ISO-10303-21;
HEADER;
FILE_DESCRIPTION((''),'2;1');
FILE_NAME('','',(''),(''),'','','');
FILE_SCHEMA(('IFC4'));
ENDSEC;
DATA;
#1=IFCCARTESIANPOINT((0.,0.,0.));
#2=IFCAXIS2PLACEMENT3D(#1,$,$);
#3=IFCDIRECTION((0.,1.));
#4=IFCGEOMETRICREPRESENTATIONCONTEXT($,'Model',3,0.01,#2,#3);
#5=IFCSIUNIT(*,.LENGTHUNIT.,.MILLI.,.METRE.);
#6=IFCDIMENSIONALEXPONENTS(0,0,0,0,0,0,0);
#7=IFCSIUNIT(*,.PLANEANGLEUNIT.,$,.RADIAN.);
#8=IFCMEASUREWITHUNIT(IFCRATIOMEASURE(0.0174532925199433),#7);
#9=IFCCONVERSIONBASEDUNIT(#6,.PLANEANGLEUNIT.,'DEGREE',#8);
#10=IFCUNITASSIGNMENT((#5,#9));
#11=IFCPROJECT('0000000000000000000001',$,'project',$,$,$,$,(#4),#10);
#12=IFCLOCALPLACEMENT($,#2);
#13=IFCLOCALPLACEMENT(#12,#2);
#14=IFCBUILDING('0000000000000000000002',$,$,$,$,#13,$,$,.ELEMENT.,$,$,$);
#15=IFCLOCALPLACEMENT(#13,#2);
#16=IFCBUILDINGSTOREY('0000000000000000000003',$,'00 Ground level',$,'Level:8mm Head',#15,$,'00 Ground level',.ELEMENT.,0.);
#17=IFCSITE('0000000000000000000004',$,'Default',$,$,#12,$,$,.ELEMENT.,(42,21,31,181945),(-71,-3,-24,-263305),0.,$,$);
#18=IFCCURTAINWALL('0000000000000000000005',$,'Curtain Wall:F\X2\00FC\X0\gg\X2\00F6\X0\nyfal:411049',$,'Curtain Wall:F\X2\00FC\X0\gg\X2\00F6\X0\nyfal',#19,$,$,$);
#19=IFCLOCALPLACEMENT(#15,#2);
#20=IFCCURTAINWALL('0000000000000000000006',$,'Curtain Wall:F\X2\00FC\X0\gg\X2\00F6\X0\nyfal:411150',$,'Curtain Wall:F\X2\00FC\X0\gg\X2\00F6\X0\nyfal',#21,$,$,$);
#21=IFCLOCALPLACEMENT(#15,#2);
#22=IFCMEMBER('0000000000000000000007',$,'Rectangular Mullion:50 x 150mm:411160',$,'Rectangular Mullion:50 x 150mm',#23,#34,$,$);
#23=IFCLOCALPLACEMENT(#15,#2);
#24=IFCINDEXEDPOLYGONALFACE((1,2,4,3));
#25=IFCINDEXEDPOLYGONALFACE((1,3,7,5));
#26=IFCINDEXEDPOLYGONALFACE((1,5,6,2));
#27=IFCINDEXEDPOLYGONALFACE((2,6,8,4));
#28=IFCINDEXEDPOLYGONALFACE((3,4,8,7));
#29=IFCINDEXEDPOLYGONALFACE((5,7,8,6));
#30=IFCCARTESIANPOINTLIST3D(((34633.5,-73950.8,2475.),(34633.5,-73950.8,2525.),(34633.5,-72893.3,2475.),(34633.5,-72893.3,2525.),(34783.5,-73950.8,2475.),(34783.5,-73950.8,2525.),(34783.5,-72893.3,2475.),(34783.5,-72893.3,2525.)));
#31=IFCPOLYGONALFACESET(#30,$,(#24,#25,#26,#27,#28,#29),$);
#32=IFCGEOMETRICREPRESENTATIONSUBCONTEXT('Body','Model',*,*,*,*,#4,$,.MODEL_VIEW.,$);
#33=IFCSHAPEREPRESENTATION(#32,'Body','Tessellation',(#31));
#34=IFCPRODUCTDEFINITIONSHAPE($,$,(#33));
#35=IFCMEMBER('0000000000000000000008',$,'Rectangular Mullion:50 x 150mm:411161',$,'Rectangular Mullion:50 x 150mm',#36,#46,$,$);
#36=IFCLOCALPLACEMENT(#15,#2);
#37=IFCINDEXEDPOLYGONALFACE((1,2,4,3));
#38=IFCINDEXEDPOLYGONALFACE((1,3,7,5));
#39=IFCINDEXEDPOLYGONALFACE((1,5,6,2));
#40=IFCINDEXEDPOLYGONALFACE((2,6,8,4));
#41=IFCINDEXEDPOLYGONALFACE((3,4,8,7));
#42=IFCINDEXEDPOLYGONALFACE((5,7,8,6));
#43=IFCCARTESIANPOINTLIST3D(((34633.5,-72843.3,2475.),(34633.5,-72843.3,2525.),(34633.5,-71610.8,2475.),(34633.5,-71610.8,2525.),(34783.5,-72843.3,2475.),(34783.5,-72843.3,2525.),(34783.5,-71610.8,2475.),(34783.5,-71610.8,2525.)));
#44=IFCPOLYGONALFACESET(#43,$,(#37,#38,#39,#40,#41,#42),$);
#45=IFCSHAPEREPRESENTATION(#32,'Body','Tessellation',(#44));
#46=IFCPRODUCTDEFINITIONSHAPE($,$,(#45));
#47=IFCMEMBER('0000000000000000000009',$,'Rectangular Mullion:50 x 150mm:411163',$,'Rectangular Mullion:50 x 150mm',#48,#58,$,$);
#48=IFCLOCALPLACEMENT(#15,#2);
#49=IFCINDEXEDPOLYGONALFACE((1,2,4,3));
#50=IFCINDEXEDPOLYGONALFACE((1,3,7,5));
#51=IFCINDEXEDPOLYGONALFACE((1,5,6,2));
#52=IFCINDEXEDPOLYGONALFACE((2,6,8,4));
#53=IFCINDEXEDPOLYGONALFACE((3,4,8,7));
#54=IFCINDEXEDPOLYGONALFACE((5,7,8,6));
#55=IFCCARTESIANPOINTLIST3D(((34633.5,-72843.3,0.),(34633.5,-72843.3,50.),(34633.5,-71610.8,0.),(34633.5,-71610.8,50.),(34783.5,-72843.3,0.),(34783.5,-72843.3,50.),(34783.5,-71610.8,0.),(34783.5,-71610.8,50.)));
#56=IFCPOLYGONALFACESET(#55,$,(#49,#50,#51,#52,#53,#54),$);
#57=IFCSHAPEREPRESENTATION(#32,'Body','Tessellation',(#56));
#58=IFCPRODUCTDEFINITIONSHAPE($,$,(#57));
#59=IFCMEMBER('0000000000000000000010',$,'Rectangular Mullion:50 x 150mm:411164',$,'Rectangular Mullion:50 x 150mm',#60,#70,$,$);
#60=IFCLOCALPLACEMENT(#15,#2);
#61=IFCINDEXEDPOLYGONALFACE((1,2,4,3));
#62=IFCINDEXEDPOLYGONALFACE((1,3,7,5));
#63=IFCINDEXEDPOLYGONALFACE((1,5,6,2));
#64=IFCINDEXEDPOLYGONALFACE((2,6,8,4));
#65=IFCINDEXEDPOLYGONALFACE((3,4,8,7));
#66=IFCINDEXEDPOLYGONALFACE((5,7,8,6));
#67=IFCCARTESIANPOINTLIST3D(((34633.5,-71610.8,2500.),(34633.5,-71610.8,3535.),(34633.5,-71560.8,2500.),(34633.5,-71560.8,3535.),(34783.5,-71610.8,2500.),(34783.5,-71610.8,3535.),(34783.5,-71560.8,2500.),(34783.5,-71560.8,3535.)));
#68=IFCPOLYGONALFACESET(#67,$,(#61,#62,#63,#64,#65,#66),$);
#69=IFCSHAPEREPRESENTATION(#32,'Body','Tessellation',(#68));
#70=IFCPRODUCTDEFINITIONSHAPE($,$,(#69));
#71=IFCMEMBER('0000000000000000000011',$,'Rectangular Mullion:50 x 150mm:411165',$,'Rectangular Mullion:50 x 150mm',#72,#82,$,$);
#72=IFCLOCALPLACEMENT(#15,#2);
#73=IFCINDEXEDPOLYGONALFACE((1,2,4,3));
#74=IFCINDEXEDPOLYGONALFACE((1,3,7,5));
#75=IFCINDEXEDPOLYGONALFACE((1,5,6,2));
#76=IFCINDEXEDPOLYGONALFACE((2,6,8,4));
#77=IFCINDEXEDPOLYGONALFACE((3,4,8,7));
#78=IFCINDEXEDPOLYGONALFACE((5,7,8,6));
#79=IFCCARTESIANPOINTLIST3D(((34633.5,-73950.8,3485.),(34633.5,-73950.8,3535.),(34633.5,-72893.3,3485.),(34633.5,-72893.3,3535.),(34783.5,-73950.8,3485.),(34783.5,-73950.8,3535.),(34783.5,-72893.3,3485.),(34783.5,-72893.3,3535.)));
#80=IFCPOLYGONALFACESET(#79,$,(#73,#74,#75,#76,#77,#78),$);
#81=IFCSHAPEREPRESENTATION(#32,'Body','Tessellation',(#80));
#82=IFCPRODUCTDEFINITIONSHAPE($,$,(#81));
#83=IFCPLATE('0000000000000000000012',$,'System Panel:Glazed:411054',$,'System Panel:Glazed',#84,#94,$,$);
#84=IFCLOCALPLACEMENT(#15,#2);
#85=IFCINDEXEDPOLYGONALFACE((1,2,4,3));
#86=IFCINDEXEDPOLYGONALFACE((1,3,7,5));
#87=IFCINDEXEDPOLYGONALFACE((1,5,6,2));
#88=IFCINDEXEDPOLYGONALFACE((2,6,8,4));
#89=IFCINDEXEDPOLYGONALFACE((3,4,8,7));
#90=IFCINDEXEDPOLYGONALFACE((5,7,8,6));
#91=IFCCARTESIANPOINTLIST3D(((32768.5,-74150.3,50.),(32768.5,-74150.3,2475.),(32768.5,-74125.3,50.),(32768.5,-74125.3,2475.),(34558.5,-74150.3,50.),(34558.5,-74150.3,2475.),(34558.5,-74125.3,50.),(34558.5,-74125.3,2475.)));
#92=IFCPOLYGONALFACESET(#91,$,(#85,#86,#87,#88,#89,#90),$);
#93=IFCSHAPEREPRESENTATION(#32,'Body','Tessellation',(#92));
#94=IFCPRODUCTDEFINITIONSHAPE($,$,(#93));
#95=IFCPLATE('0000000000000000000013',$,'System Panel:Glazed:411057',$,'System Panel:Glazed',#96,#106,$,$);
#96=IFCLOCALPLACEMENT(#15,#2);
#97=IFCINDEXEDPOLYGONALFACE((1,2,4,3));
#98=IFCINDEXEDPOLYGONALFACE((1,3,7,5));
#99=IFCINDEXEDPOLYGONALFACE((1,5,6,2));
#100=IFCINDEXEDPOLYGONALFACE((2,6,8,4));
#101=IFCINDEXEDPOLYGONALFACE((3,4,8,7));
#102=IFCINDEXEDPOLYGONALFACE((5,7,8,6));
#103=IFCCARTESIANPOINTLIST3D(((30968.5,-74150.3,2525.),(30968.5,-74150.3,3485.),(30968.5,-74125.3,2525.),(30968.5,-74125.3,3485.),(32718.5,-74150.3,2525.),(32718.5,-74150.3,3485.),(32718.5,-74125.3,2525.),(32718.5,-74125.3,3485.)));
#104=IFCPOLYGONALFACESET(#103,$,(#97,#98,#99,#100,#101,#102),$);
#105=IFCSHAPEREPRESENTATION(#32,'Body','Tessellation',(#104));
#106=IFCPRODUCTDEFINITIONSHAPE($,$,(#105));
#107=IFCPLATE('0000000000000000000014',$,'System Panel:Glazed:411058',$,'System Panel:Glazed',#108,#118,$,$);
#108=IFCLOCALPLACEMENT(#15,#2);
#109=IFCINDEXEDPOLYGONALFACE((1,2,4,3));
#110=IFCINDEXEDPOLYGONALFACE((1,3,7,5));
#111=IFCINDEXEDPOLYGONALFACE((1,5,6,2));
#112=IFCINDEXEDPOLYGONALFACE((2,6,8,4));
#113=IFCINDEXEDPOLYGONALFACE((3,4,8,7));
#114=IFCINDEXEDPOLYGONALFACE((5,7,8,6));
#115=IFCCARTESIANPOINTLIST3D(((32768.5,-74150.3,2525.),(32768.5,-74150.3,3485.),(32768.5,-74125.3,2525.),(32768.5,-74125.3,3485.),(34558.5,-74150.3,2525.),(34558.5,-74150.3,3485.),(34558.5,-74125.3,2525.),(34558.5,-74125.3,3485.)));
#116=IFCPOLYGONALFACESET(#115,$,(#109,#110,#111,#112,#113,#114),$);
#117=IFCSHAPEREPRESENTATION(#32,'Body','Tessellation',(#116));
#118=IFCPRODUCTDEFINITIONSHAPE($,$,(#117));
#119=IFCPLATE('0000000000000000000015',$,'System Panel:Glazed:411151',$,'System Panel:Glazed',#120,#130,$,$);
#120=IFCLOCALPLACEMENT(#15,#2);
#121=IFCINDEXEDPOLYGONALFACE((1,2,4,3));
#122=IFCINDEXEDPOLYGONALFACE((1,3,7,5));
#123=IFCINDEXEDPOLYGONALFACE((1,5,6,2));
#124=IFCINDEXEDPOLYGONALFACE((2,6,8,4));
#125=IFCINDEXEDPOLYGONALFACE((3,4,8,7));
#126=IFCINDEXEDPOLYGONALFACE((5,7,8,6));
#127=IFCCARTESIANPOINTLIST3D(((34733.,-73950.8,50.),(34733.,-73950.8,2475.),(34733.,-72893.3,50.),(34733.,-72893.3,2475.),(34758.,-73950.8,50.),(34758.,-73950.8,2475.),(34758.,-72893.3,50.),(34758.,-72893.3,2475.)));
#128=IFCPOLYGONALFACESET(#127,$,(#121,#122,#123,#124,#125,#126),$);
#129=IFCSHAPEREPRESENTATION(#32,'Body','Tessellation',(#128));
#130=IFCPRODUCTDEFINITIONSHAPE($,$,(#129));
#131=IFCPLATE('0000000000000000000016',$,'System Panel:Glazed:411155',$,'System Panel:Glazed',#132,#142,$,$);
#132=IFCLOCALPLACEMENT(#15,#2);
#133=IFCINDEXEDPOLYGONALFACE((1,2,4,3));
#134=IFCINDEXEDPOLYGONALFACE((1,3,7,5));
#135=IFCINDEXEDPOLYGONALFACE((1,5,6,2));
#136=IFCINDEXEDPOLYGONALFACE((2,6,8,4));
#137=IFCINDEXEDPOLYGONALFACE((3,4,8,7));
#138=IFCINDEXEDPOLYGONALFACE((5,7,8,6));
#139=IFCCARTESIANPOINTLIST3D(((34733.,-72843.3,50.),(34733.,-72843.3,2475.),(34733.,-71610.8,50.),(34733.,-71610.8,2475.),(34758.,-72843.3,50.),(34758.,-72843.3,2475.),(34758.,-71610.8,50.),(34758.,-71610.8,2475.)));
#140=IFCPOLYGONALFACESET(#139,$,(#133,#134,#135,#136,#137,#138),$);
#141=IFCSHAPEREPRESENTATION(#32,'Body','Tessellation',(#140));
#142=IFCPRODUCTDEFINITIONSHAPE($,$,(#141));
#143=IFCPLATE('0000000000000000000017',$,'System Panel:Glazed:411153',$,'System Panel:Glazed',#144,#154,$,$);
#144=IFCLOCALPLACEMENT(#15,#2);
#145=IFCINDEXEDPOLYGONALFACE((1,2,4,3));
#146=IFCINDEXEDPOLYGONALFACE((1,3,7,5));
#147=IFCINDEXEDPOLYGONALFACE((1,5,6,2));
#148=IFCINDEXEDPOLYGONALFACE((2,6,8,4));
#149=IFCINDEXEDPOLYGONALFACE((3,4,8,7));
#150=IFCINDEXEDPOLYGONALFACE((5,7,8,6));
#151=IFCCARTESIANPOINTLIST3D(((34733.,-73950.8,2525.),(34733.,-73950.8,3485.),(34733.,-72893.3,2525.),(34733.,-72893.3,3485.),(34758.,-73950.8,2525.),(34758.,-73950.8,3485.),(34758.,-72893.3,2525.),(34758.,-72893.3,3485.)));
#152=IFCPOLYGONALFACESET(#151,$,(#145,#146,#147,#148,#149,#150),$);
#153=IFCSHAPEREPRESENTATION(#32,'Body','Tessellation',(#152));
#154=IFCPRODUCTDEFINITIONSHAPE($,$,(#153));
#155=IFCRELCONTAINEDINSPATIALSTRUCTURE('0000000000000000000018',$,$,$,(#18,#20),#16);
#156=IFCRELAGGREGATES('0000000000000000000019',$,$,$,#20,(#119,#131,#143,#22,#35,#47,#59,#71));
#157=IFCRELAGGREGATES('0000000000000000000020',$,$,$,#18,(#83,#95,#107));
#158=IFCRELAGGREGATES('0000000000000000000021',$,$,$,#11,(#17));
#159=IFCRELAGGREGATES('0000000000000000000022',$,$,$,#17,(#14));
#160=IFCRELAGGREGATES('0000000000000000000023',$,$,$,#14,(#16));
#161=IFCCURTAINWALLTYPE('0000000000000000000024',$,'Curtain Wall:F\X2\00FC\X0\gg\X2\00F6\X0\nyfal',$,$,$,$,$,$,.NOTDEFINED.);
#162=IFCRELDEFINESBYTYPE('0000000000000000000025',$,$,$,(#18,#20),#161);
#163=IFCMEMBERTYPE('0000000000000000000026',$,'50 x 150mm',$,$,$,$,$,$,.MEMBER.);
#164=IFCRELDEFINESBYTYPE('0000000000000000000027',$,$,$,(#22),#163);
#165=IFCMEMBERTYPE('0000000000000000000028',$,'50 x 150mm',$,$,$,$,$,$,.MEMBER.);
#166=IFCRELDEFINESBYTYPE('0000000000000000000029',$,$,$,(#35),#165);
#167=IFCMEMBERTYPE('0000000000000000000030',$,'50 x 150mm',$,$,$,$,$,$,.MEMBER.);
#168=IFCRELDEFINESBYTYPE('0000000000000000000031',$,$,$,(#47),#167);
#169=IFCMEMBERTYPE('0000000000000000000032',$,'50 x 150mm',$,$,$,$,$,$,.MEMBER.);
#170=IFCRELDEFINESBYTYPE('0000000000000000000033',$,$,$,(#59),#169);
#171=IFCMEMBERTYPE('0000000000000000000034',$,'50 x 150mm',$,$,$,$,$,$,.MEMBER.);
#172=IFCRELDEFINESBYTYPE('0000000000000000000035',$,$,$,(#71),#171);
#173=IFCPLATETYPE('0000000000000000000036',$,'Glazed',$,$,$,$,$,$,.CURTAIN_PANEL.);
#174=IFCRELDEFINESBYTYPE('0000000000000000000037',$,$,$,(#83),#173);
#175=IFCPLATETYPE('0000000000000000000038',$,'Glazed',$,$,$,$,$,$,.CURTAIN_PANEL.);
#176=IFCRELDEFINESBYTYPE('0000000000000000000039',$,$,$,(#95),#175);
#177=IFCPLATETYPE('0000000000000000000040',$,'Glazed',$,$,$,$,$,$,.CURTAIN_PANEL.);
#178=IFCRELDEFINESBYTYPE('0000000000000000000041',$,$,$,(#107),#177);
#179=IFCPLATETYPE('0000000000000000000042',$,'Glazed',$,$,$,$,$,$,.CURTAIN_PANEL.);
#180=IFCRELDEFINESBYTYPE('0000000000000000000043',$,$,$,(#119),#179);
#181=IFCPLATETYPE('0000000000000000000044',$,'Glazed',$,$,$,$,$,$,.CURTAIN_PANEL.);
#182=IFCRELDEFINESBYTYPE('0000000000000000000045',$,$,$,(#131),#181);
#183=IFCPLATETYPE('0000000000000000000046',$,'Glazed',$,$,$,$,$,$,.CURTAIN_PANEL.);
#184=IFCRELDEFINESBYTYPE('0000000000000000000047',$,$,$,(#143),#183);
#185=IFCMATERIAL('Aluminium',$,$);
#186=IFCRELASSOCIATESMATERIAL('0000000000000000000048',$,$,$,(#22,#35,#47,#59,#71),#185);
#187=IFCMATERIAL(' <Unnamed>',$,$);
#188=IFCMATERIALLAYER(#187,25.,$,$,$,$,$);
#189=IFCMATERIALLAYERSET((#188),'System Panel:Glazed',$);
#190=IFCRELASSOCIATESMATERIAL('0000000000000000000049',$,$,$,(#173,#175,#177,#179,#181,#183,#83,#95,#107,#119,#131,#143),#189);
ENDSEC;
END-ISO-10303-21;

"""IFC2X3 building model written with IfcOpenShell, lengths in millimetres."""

from ifc_helpers import new_model, entity, si_unit, converted_unit, direction, frame, frame_2d, origin, origin_2d_with_axis, place, context, subcontext, project, spatial, rectangle, extrude, source, transform, mapped, material, layer, layer_set, layer_usage, type_object, type_shapes, element, aggregate, save


model = new_model("IFC2X3")

# Units and contexts
model_context = context("Model", 3, precision=0.01, world=origin(), true_north=direction((0.0, 1.0)))
body_context = subcontext(model_context, "Body", "Model", "MODEL_VIEW")
ifc_project = project(units=[si_unit("LENGTHUNIT", "METRE", prefix="MILLI"), converted_unit("PLANEANGLEUNIT", "DEGREE", entity("IfcRatioMeasure", 0.0174532925199433), si_unit("PLANEANGLEUNIT", "RADIAN"), dimensions=[0, 0, 0, 0, 0, 0, 0])], contexts=[model_context])

# Site, building, storey
site_placement = place(None, origin())
site = spatial("IfcSite", under=ifc_project, at=site_placement, Name="Default", CompositionType="ELEMENT", RefLatitude=(42, 21, 31, 181945), RefLongitude=(-71, -3, -24, -263305), RefElevation=0.0)
building_placement = place(site_placement, origin())
building = spatial("IfcBuilding", under=site, at=building_placement, CompositionType="ELEMENT")
storey_placement = place(building_placement, origin())
storey = spatial("IfcBuildingStorey", under=building, at=storey_placement, Name="00 Ground level", ObjectType="Level:8mm Head", LongName="00 Ground level", CompositionType="ELEMENT", Elevation=0.0)

# Curtain wall
curtain_wall_type = type_object("IfcCurtainWallType", Name="Curtain Wall:Függönyfal", PredefinedType="NOTDEFINED")
curtain_wall_1_placement = place(storey_placement, origin())
curtain_wall_1 = element("IfcCurtainWall", 1, at=curtain_wall_1_placement, inside=storey, type_object=curtain_wall_type, Name="Curtain Wall:Függönyfal:411049", ObjectType="Curtain Wall:Függönyfal")
ifc_material_1 = material(Name="Aluminium")

# Curtain wall
curtain_wall_2_placement = place(storey_placement, origin())
curtain_wall_2 = element("IfcCurtainWall", 2, at=curtain_wall_2_placement, inside=storey, type_object=curtain_wall_type, Name="Curtain Wall:Függönyfal:411150", ObjectType="Curtain Wall:Függönyfal")

# Members
member_type_1 = type_object("IfcMemberType", Name="50 x 150mm", PredefinedType="MEMBER")
shared_shape_1 = source(origin(), body_context, "Body", "SweptSolid", [
    extrude(rectangle(XDim=150.0, YDim=50.0, at=origin_2d_with_axis()), frame((0.0, 0.0, -1057.5), z_axis=(0.0, 0.0, 1.0), x_axis=(0.0, -1.0, 0.0)), (0.0, 0.0, 1.0), 1057.5),
])
type_shapes(member_type_1, [shared_shape_1])
member_1_placement = place(storey_placement, frame((34708.5, -72893.3, 2500.0), z_axis=(0.0, 1.0, 0.0), x_axis=(0.0, 0.0, 1.0)))
member_1 = element("IfcMember", 3, at=member_1_placement, type_object=member_type_1, material=ifc_material_1, Name="Rectangular Mullion:50 x 150mm:411160", ObjectType="Rectangular Mullion:50 x 150mm", context=body_context, shape_type="MappedRepresentation", body=[
    mapped(shared_shape_1, transform((0.0, 0.0, 0.0), scale=1.0)),
])
member_type_2 = type_object("IfcMemberType", Name="50 x 150mm", PredefinedType="MEMBER")
shared_shape_2 = source(origin(), body_context, "Body", "SweptSolid", [
    extrude(rectangle(XDim=150.0, YDim=50.0, at=origin_2d_with_axis()), frame((0.0, 0.0, -1232.5), z_axis=(0.0, 0.0, 1.0), x_axis=(0.0, -1.0, 0.0)), (0.0, 0.0, 1.0), 1232.5),
])
type_shapes(member_type_2, [shared_shape_2])
member_2_placement = place(storey_placement, frame((34708.5, -71610.8, 2500.0), z_axis=(0.0, 1.0, 0.0), x_axis=(0.0, 0.0, 1.0)))
member_2 = element("IfcMember", 4, at=member_2_placement, type_object=member_type_2, material=ifc_material_1, Name="Rectangular Mullion:50 x 150mm:411161", ObjectType="Rectangular Mullion:50 x 150mm", context=body_context, shape_type="MappedRepresentation", body=[
    mapped(shared_shape_2, transform((0.0, 0.0, 0.0), scale=1.0)),
])
member_type_3 = type_object("IfcMemberType", Name="50 x 150mm", PredefinedType="MEMBER")
shared_shape_3 = source(origin(), body_context, "Body", "SweptSolid", [
    extrude(rectangle(XDim=150.0, YDim=50.0, at=origin_2d_with_axis()), frame((-25.0, 0.0, -1232.5), z_axis=(0.0, 0.0, 1.0), x_axis=(0.0, -1.0, 0.0)), (0.0, 0.0, 1.0), 1232.5),
])
type_shapes(member_type_3, [shared_shape_3])
member_3_placement = place(storey_placement, frame((34708.5, -72843.3, 0.0), z_axis=(0.0, -1.0, 0.0), x_axis=(0.0, 0.0, -1.0)))
member_3 = element("IfcMember", 5, at=member_3_placement, type_object=member_type_3, material=ifc_material_1, Name="Rectangular Mullion:50 x 150mm:411163", ObjectType="Rectangular Mullion:50 x 150mm", context=body_context, shape_type="MappedRepresentation", body=[
    mapped(shared_shape_3, transform((0.0, 0.0, 0.0), scale=1.0)),
])
member_type_4 = type_object("IfcMemberType", Name="50 x 150mm", PredefinedType="MEMBER")
shared_shape_4 = source(origin(), body_context, "Body", "SweptSolid", [
    extrude(rectangle(XDim=150.0, YDim=50.0, at=origin_2d_with_axis()), frame((-25.0, 0.0, -1035.0), z_axis=(0.0, 0.0, 1.0), x_axis=(0.0, -1.0, 0.0)), (0.0, 0.0, 1.0), 1035.0),
])
type_shapes(member_type_4, [shared_shape_4])
member_4_placement = place(storey_placement, frame((34708.5, -71560.8, 2500.0), z_axis=(0.0, 0.0, -1.0), x_axis=(0.0, 1.0, 0.0)))
member_4 = element("IfcMember", 6, at=member_4_placement, type_object=member_type_4, material=ifc_material_1, Name="Rectangular Mullion:50 x 150mm:411164", ObjectType="Rectangular Mullion:50 x 150mm", context=body_context, shape_type="MappedRepresentation", body=[
    mapped(shared_shape_4, transform((0.0, 0.0, 0.0), scale=1.0)),
])
member_type_5 = type_object("IfcMemberType", Name="50 x 150mm", PredefinedType="MEMBER")
shared_shape_5 = source(origin(), body_context, "Body", "SweptSolid", [
    extrude(rectangle(XDim=150.0, YDim=50.0, at=origin_2d_with_axis()), frame((-25.0, 0.0, -1057.5), z_axis=(0.0, 0.0, 1.0), x_axis=(0.0, -1.0, 0.0)), (0.0, 0.0, 1.0), 1057.5),
])
type_shapes(member_type_5, [shared_shape_5])
member_5_placement = place(storey_placement, frame((34708.5, -72893.3, 3535.0), z_axis=(0.0, 1.0, 0.0), x_axis=(0.0, 0.0, 1.0)))
member_5 = element("IfcMember", 7, at=member_5_placement, type_object=member_type_5, material=ifc_material_1, Name="Rectangular Mullion:50 x 150mm:411165", ObjectType="Rectangular Mullion:50 x 150mm", context=body_context, shape_type="MappedRepresentation", body=[
    mapped(shared_shape_5, transform((0.0, 0.0, 0.0), scale=1.0)),
])

# Plates
ifc_material_2 = material(Name=" <Unnamed>")
ifc_layer_1 = layer(ifc_material_2, 25.0)
ifc_layer_set_1 = layer_set([ifc_layer_1], Name="System Panel:Glazed")
ifc_layer_usage_1 = layer_usage(ifc_layer_set_1, "AXIS3", "POSITIVE", 0.1)
plate_type_1 = type_object("IfcPlateType", Name="Glazed", PredefinedType="CURTAIN_PANEL", material=ifc_layer_set_1)
shared_shape_6 = source(origin(), body_context, "Body", "SweptSolid", [
    extrude(rectangle(XDim=25.0, YDim=1790.0, at=frame_2d((0.0, 0.0), x_axis=(1.0, 0.0))), frame((895.0, 12.5, 0.0), z_axis=(0.0, 0.0, 1.0), x_axis=(0.0, 1.0, 0.0)), (0.0, 0.0, 1.0), 2425.0),
])
type_shapes(plate_type_1, [shared_shape_6])
plate_1_placement = place(curtain_wall_1_placement, frame((32768.5, -74150.3, 50.0)))
plate_1 = element("IfcPlate", 8, at=plate_1_placement, type_object=plate_type_1, material=ifc_layer_usage_1, Name="System Panel:Glazed:411054", ObjectType="System Panel:Glazed", context=body_context, shape_type="MappedRepresentation", body=[
    mapped(shared_shape_6, transform((0.0, 0.0, 0.0), scale=1.0)),
])
ifc_layer_usage_2 = layer_usage(ifc_layer_set_1, "AXIS3", "POSITIVE", 0.1)
plate_type_2 = type_object("IfcPlateType", Name="Glazed", PredefinedType="CURTAIN_PANEL", material=ifc_layer_set_1)
shared_shape_7 = source(origin(), body_context, "Body", "SweptSolid", [
    extrude(rectangle(XDim=25.0, YDim=1750.0, at=frame_2d((0.0, 0.0), x_axis=(1.0, 0.0))), frame((875.0, 12.5, 0.0), z_axis=(0.0, 0.0, 1.0), x_axis=(0.0, 1.0, 0.0)), (0.0, 0.0, 1.0), 960.0),
])
type_shapes(plate_type_2, [shared_shape_7])
plate_2_placement = place(curtain_wall_1_placement, frame((30968.5, -74150.3, 2525.0)))
plate_2 = element("IfcPlate", 9, at=plate_2_placement, type_object=plate_type_2, material=ifc_layer_usage_2, Name="System Panel:Glazed:411057", ObjectType="System Panel:Glazed", context=body_context, shape_type="MappedRepresentation", body=[
    mapped(shared_shape_7, transform((0.0, 0.0, 0.0), scale=1.0)),
])
ifc_layer_usage_3 = layer_usage(ifc_layer_set_1, "AXIS3", "POSITIVE", 0.1)
plate_type_3 = type_object("IfcPlateType", Name="Glazed", PredefinedType="CURTAIN_PANEL", material=ifc_layer_set_1)
shared_shape_8 = source(origin(), body_context, "Body", "SweptSolid", [
    extrude(rectangle(XDim=25.0, YDim=1790.0, at=frame_2d((0.0, 0.0), x_axis=(1.0, 0.0))), frame((895.0, 12.5, 0.0), z_axis=(0.0, 0.0, 1.0), x_axis=(0.0, 1.0, 0.0)), (0.0, 0.0, 1.0), 960.0),
])
type_shapes(plate_type_3, [shared_shape_8])
plate_3_placement = place(curtain_wall_1_placement, frame((32768.5, -74150.3, 2525.0)))
plate_3 = element("IfcPlate", 10, at=plate_3_placement, type_object=plate_type_3, material=ifc_layer_usage_3, Name="System Panel:Glazed:411058", ObjectType="System Panel:Glazed", context=body_context, shape_type="MappedRepresentation", body=[
    mapped(shared_shape_8, transform((0.0, 0.0, 0.0), scale=1.0)),
])
ifc_layer_usage_4 = layer_usage(ifc_layer_set_1, "AXIS3", "POSITIVE", 0.1)
plate_type_4 = type_object("IfcPlateType", Name="Glazed", PredefinedType="CURTAIN_PANEL", material=ifc_layer_set_1)
shared_shape_9 = source(origin(), body_context, "Body", "SweptSolid", [
    extrude(rectangle(XDim=25.0, YDim=1057.5, at=origin_2d_with_axis()), frame((528.7, 12.5, 0.0), z_axis=(0.0, 0.0, 1.0), x_axis=(0.0, 1.0, 0.0)), (0.0, 0.0, 1.0), 2425.0),
])
type_shapes(plate_type_4, [shared_shape_9])
plate_4_placement = place(curtain_wall_2_placement, frame((34758.0, -73950.8, 50.0), z_axis=(0.0, 0.0, 1.0), x_axis=(0.0, 1.0, 0.0)))
plate_4 = element("IfcPlate", 11, at=plate_4_placement, type_object=plate_type_4, material=ifc_layer_usage_4, Name="System Panel:Glazed:411151", ObjectType="System Panel:Glazed", context=body_context, shape_type="MappedRepresentation", body=[
    mapped(shared_shape_9, transform((0.0, 0.0, 0.0), scale=1.0)),
])
ifc_layer_usage_5 = layer_usage(ifc_layer_set_1, "AXIS3", "POSITIVE", 0.1)
plate_type_5 = type_object("IfcPlateType", Name="Glazed", PredefinedType="CURTAIN_PANEL", material=ifc_layer_set_1)
shared_shape_10 = source(origin(), body_context, "Body", "SweptSolid", [
    extrude(rectangle(XDim=25.0, YDim=1232.5, at=frame_2d((0.0, 0.0), x_axis=(1.0, 0.0))), frame((616.2, 12.5, 0.0), z_axis=(0.0, 0.0, 1.0), x_axis=(0.0, 1.0, 0.0)), (0.0, 0.0, 1.0), 2425.0),
])
type_shapes(plate_type_5, [shared_shape_10])
plate_5_placement = place(curtain_wall_2_placement, frame((34758.0, -72843.3, 50.0), z_axis=(0.0, 0.0, 1.0), x_axis=(0.0, 1.0, 0.0)))
plate_5 = element("IfcPlate", 12, at=plate_5_placement, type_object=plate_type_5, material=ifc_layer_usage_5, Name="System Panel:Glazed:411155", ObjectType="System Panel:Glazed", context=body_context, shape_type="MappedRepresentation", body=[
    mapped(shared_shape_10, transform((0.0, 0.0, 0.0), scale=1.0)),
])
ifc_layer_usage_6 = layer_usage(ifc_layer_set_1, "AXIS3", "POSITIVE", 0.1)
plate_type_6 = type_object("IfcPlateType", Name="Glazed", PredefinedType="CURTAIN_PANEL", material=ifc_layer_set_1)
shared_shape_11 = source(origin(), body_context, "Body", "SweptSolid", [
    extrude(rectangle(XDim=25.0, YDim=1057.5, at=origin_2d_with_axis()), frame((528.7, 12.5, 0.0), z_axis=(0.0, 0.0, 1.0), x_axis=(0.0, 1.0, 0.0)), (0.0, 0.0, 1.0), 960.0),
])
type_shapes(plate_type_6, [shared_shape_11])
plate_6_placement = place(curtain_wall_2_placement, frame((34758.0, -73950.8, 2525.0), z_axis=(0.0, 0.0, 1.0), x_axis=(0.0, 1.0, 0.0)))
plate_6 = element("IfcPlate", 13, at=plate_6_placement, type_object=plate_type_6, material=ifc_layer_usage_6, Name="System Panel:Glazed:411153", ObjectType="System Panel:Glazed", context=body_context, shape_type="MappedRepresentation", body=[
    mapped(shared_shape_11, transform((0.0, 0.0, 0.0), scale=1.0)),
])
aggregate(curtain_wall_2, [plate_4, plate_5, plate_6, member_1, member_2, member_3, member_4, member_5])

aggregate(curtain_wall_1, [plate_1, plate_2, plate_3])

save(model, "model.ifc")
